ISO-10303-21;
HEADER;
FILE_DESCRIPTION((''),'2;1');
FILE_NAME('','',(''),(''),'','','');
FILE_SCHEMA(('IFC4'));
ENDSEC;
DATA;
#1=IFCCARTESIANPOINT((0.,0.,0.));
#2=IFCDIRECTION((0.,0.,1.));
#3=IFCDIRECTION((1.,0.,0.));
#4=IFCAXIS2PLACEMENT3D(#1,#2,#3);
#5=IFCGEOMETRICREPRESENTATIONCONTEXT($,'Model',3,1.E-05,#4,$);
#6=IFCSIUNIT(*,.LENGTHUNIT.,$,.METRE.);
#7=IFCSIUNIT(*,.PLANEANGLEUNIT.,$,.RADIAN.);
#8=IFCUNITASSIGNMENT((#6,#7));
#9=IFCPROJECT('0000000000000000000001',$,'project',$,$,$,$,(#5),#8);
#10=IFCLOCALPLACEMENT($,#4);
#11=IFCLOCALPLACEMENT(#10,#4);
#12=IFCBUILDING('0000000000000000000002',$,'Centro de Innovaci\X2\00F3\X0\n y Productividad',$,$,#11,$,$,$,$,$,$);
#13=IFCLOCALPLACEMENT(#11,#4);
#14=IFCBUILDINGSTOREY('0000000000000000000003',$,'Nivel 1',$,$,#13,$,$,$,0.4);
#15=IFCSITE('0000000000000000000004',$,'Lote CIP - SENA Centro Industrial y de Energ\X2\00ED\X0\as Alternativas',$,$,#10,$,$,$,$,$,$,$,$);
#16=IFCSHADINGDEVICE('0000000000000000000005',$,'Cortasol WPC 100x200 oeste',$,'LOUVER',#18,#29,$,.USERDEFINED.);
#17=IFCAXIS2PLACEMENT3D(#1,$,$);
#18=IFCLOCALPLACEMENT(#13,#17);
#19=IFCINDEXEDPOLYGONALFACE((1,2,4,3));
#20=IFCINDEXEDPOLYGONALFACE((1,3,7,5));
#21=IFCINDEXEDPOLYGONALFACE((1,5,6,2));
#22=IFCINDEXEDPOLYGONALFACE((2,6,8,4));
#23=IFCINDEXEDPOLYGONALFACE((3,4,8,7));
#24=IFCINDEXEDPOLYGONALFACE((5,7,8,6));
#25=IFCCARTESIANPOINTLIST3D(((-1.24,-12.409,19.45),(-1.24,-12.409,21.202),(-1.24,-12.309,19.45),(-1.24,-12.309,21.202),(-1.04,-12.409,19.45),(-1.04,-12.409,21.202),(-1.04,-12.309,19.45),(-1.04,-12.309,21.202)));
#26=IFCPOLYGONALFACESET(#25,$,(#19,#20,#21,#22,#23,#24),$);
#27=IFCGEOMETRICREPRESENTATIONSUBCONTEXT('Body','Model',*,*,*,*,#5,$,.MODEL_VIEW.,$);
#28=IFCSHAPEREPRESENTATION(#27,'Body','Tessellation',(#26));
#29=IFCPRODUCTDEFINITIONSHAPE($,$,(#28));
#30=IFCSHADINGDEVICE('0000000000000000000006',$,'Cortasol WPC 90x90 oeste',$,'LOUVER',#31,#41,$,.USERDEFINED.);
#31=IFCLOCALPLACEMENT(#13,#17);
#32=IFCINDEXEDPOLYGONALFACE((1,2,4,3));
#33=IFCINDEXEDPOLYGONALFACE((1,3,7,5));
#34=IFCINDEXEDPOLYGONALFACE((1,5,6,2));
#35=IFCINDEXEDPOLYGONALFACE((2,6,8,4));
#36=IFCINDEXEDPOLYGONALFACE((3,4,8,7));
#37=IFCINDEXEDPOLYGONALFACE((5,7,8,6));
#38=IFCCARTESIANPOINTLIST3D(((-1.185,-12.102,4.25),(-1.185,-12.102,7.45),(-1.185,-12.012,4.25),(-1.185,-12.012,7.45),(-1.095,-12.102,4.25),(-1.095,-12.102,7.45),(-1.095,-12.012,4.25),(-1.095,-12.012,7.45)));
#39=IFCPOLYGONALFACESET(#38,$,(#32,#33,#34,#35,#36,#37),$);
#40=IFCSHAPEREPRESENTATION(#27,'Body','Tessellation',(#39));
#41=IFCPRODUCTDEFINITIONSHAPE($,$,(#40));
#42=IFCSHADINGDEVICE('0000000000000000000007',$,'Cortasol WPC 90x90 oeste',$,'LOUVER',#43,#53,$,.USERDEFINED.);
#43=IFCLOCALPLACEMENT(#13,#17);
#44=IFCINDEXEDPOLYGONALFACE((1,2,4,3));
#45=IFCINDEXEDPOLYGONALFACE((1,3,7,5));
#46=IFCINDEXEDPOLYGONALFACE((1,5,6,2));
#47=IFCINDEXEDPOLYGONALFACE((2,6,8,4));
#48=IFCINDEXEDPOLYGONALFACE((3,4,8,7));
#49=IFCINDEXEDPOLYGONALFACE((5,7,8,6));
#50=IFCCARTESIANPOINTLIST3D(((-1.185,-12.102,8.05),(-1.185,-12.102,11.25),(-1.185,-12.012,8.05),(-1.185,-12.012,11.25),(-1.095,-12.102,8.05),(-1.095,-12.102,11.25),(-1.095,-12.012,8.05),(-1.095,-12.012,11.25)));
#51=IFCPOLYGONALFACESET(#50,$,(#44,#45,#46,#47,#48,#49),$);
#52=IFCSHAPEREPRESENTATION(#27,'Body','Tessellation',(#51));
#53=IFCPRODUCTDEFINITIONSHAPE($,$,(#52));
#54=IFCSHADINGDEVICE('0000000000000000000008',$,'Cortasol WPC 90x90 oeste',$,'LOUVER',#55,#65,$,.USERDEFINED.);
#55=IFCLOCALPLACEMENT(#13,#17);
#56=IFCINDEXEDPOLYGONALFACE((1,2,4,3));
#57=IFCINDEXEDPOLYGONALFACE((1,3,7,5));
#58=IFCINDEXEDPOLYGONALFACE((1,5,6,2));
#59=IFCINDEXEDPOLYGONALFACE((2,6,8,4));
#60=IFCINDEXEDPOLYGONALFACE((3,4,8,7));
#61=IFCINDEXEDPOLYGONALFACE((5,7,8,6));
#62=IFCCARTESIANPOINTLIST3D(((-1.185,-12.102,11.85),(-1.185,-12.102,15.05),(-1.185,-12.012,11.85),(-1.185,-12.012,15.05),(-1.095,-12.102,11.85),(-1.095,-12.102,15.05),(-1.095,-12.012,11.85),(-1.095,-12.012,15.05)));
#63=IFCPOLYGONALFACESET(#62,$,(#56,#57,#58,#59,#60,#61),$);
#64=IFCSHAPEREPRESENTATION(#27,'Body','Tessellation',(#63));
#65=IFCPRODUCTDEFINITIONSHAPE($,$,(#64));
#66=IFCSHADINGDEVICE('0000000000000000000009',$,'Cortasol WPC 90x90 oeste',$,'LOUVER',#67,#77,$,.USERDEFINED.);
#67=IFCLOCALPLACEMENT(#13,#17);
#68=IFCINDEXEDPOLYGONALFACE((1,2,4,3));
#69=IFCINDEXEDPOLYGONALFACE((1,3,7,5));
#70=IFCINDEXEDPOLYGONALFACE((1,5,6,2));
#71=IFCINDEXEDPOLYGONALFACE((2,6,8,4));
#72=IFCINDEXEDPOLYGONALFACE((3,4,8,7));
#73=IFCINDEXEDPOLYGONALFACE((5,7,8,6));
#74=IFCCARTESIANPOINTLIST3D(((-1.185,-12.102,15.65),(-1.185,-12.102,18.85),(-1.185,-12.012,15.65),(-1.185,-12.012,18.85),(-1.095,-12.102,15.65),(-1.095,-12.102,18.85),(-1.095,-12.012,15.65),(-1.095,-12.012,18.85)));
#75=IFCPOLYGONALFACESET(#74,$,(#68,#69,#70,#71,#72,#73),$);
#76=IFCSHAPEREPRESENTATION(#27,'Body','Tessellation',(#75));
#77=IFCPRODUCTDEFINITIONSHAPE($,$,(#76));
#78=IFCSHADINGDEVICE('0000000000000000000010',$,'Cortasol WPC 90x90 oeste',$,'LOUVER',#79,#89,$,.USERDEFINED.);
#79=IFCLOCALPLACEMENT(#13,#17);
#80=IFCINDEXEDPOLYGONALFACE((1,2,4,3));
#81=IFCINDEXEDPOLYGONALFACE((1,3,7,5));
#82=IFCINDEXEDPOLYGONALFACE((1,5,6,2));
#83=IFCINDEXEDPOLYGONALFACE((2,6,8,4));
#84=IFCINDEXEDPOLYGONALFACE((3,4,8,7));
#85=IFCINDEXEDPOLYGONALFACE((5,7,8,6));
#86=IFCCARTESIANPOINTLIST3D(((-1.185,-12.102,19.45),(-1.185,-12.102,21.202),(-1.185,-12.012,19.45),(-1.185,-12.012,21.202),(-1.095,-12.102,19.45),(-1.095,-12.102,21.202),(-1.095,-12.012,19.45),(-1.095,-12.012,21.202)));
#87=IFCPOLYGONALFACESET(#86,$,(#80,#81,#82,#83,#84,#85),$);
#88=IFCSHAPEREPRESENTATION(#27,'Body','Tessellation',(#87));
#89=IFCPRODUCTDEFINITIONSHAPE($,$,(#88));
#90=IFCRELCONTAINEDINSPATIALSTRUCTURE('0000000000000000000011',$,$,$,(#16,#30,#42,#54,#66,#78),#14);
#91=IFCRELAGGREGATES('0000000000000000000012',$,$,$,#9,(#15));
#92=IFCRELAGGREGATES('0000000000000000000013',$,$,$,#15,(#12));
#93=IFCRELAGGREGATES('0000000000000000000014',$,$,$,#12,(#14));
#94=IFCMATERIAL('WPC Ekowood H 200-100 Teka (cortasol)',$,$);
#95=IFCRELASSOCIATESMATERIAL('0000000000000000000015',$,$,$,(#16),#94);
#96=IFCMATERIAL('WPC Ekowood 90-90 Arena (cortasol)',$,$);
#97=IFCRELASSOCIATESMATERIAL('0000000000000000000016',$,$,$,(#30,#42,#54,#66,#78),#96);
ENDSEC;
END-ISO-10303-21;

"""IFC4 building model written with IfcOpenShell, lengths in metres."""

from ifc_helpers import new_model, si_unit, frame, origin_with_axes, place, context, subcontext, project, spatial, polyline, outline, extrude, material, element, save


model = new_model("IFC4")

# Units and contexts
model_context = context("Model", 3, precision=1e-05, world=origin_with_axes())
body_context = subcontext(model_context, "Body", "Model", "MODEL_VIEW")
ifc_project = project(units=[si_unit("LENGTHUNIT", "METRE"), si_unit("PLANEANGLEUNIT", "RADIAN")], contexts=[model_context])

# Site, building, storey
site_placement = place(None, origin_with_axes())
site = spatial("IfcSite", under=ifc_project, at=site_placement, Name="Lote CIP - SENA Centro Industrial y de Energías Alternativas")
building_placement = place(site_placement, origin_with_axes())
building = spatial("IfcBuilding", under=site, at=building_placement, Name="Centro de Innovación y Productividad")
storey_placement = place(building_placement, origin_with_axes())
storey = spatial("IfcBuildingStorey", under=building, at=storey_placement, Name="Nivel 1", Elevation=0.4)

# Shading devices
ifc_material_1 = material(Name="WPC Ekowood 90-90 Arena (cortasol)")
ifc_material_2 = material(Name="WPC Ekowood H 200-100 Teka (cortasol)")
shading_device_1_placement = place(storey_placement, origin_with_axes())
element("IfcShadingDevice", 1, at=shading_device_1_placement, inside=storey, material=ifc_material_2, Name="Cortasol WPC 100x200 oeste", ObjectType="LOUVER", PredefinedType="USERDEFINED", context=body_context, shape_type="SweptSolid", body=[
    extrude(outline(polyline([(-1.04, -12.409), (-1.24, -12.409), (-1.24, -12.309), (-1.04, -12.309), (-1.04, -12.409)])), frame((0.0, 0.0, 19.45)), (0.0, 0.0, 1.0), 1.752),
])
shading_device_2_placement = place(storey_placement, origin_with_axes())
element("IfcShadingDevice", 2, at=shading_device_2_placement, inside=storey, material=ifc_material_1, Name="Cortasol WPC 90x90 oeste", ObjectType="LOUVER", PredefinedType="USERDEFINED", context=body_context, shape_type="SweptSolid", body=[
    extrude(outline(polyline([(-1.095, -12.102), (-1.185, -12.102), (-1.185, -12.012), (-1.095, -12.012), (-1.095, -12.102)])), frame((0.0, 0.0, 4.25)), (0.0, 0.0, 1.0), 3.2),
])
shading_device_3_placement = place(storey_placement, origin_with_axes())
element("IfcShadingDevice", 3, at=shading_device_3_placement, inside=storey, material=ifc_material_1, Name="Cortasol WPC 90x90 oeste", ObjectType="LOUVER", PredefinedType="USERDEFINED", context=body_context, shape_type="SweptSolid", body=[
    extrude(outline(polyline([(-1.095, -12.102), (-1.185, -12.102), (-1.185, -12.012), (-1.095, -12.012), (-1.095, -12.102)])), frame((0.0, 0.0, 8.05)), (0.0, 0.0, 1.0), 3.2),
])
shading_device_4_placement = place(storey_placement, origin_with_axes())
element("IfcShadingDevice", 4, at=shading_device_4_placement, inside=storey, material=ifc_material_1, Name="Cortasol WPC 90x90 oeste", ObjectType="LOUVER", PredefinedType="USERDEFINED", context=body_context, shape_type="SweptSolid", body=[
    extrude(outline(polyline([(-1.095, -12.102), (-1.185, -12.102), (-1.185, -12.012), (-1.095, -12.012), (-1.095, -12.102)])), frame((0.0, 0.0, 11.85)), (0.0, 0.0, 1.0), 3.2),
])
shading_device_5_placement = place(storey_placement, origin_with_axes())
element("IfcShadingDevice", 5, at=shading_device_5_placement, inside=storey, material=ifc_material_1, Name="Cortasol WPC 90x90 oeste", ObjectType="LOUVER", PredefinedType="USERDEFINED", context=body_context, shape_type="SweptSolid", body=[
    extrude(outline(polyline([(-1.095, -12.102), (-1.185, -12.102), (-1.185, -12.012), (-1.095, -12.012), (-1.095, -12.102)])), frame((0.0, 0.0, 15.65)), (0.0, 0.0, 1.0), 3.2),
])
shading_device_6_placement = place(storey_placement, origin_with_axes())
element("IfcShadingDevice", 6, at=shading_device_6_placement, inside=storey, material=ifc_material_1, Name="Cortasol WPC 90x90 oeste", ObjectType="LOUVER", PredefinedType="USERDEFINED", context=body_context, shape_type="SweptSolid", body=[
    extrude(outline(polyline([(-1.095, -12.102), (-1.185, -12.102), (-1.185, -12.012), (-1.095, -12.012), (-1.095, -12.102)])), frame((0.0, 0.0, 19.45)), (0.0, 0.0, 1.0), 1.752),
])

save(model, "model.ifc")
